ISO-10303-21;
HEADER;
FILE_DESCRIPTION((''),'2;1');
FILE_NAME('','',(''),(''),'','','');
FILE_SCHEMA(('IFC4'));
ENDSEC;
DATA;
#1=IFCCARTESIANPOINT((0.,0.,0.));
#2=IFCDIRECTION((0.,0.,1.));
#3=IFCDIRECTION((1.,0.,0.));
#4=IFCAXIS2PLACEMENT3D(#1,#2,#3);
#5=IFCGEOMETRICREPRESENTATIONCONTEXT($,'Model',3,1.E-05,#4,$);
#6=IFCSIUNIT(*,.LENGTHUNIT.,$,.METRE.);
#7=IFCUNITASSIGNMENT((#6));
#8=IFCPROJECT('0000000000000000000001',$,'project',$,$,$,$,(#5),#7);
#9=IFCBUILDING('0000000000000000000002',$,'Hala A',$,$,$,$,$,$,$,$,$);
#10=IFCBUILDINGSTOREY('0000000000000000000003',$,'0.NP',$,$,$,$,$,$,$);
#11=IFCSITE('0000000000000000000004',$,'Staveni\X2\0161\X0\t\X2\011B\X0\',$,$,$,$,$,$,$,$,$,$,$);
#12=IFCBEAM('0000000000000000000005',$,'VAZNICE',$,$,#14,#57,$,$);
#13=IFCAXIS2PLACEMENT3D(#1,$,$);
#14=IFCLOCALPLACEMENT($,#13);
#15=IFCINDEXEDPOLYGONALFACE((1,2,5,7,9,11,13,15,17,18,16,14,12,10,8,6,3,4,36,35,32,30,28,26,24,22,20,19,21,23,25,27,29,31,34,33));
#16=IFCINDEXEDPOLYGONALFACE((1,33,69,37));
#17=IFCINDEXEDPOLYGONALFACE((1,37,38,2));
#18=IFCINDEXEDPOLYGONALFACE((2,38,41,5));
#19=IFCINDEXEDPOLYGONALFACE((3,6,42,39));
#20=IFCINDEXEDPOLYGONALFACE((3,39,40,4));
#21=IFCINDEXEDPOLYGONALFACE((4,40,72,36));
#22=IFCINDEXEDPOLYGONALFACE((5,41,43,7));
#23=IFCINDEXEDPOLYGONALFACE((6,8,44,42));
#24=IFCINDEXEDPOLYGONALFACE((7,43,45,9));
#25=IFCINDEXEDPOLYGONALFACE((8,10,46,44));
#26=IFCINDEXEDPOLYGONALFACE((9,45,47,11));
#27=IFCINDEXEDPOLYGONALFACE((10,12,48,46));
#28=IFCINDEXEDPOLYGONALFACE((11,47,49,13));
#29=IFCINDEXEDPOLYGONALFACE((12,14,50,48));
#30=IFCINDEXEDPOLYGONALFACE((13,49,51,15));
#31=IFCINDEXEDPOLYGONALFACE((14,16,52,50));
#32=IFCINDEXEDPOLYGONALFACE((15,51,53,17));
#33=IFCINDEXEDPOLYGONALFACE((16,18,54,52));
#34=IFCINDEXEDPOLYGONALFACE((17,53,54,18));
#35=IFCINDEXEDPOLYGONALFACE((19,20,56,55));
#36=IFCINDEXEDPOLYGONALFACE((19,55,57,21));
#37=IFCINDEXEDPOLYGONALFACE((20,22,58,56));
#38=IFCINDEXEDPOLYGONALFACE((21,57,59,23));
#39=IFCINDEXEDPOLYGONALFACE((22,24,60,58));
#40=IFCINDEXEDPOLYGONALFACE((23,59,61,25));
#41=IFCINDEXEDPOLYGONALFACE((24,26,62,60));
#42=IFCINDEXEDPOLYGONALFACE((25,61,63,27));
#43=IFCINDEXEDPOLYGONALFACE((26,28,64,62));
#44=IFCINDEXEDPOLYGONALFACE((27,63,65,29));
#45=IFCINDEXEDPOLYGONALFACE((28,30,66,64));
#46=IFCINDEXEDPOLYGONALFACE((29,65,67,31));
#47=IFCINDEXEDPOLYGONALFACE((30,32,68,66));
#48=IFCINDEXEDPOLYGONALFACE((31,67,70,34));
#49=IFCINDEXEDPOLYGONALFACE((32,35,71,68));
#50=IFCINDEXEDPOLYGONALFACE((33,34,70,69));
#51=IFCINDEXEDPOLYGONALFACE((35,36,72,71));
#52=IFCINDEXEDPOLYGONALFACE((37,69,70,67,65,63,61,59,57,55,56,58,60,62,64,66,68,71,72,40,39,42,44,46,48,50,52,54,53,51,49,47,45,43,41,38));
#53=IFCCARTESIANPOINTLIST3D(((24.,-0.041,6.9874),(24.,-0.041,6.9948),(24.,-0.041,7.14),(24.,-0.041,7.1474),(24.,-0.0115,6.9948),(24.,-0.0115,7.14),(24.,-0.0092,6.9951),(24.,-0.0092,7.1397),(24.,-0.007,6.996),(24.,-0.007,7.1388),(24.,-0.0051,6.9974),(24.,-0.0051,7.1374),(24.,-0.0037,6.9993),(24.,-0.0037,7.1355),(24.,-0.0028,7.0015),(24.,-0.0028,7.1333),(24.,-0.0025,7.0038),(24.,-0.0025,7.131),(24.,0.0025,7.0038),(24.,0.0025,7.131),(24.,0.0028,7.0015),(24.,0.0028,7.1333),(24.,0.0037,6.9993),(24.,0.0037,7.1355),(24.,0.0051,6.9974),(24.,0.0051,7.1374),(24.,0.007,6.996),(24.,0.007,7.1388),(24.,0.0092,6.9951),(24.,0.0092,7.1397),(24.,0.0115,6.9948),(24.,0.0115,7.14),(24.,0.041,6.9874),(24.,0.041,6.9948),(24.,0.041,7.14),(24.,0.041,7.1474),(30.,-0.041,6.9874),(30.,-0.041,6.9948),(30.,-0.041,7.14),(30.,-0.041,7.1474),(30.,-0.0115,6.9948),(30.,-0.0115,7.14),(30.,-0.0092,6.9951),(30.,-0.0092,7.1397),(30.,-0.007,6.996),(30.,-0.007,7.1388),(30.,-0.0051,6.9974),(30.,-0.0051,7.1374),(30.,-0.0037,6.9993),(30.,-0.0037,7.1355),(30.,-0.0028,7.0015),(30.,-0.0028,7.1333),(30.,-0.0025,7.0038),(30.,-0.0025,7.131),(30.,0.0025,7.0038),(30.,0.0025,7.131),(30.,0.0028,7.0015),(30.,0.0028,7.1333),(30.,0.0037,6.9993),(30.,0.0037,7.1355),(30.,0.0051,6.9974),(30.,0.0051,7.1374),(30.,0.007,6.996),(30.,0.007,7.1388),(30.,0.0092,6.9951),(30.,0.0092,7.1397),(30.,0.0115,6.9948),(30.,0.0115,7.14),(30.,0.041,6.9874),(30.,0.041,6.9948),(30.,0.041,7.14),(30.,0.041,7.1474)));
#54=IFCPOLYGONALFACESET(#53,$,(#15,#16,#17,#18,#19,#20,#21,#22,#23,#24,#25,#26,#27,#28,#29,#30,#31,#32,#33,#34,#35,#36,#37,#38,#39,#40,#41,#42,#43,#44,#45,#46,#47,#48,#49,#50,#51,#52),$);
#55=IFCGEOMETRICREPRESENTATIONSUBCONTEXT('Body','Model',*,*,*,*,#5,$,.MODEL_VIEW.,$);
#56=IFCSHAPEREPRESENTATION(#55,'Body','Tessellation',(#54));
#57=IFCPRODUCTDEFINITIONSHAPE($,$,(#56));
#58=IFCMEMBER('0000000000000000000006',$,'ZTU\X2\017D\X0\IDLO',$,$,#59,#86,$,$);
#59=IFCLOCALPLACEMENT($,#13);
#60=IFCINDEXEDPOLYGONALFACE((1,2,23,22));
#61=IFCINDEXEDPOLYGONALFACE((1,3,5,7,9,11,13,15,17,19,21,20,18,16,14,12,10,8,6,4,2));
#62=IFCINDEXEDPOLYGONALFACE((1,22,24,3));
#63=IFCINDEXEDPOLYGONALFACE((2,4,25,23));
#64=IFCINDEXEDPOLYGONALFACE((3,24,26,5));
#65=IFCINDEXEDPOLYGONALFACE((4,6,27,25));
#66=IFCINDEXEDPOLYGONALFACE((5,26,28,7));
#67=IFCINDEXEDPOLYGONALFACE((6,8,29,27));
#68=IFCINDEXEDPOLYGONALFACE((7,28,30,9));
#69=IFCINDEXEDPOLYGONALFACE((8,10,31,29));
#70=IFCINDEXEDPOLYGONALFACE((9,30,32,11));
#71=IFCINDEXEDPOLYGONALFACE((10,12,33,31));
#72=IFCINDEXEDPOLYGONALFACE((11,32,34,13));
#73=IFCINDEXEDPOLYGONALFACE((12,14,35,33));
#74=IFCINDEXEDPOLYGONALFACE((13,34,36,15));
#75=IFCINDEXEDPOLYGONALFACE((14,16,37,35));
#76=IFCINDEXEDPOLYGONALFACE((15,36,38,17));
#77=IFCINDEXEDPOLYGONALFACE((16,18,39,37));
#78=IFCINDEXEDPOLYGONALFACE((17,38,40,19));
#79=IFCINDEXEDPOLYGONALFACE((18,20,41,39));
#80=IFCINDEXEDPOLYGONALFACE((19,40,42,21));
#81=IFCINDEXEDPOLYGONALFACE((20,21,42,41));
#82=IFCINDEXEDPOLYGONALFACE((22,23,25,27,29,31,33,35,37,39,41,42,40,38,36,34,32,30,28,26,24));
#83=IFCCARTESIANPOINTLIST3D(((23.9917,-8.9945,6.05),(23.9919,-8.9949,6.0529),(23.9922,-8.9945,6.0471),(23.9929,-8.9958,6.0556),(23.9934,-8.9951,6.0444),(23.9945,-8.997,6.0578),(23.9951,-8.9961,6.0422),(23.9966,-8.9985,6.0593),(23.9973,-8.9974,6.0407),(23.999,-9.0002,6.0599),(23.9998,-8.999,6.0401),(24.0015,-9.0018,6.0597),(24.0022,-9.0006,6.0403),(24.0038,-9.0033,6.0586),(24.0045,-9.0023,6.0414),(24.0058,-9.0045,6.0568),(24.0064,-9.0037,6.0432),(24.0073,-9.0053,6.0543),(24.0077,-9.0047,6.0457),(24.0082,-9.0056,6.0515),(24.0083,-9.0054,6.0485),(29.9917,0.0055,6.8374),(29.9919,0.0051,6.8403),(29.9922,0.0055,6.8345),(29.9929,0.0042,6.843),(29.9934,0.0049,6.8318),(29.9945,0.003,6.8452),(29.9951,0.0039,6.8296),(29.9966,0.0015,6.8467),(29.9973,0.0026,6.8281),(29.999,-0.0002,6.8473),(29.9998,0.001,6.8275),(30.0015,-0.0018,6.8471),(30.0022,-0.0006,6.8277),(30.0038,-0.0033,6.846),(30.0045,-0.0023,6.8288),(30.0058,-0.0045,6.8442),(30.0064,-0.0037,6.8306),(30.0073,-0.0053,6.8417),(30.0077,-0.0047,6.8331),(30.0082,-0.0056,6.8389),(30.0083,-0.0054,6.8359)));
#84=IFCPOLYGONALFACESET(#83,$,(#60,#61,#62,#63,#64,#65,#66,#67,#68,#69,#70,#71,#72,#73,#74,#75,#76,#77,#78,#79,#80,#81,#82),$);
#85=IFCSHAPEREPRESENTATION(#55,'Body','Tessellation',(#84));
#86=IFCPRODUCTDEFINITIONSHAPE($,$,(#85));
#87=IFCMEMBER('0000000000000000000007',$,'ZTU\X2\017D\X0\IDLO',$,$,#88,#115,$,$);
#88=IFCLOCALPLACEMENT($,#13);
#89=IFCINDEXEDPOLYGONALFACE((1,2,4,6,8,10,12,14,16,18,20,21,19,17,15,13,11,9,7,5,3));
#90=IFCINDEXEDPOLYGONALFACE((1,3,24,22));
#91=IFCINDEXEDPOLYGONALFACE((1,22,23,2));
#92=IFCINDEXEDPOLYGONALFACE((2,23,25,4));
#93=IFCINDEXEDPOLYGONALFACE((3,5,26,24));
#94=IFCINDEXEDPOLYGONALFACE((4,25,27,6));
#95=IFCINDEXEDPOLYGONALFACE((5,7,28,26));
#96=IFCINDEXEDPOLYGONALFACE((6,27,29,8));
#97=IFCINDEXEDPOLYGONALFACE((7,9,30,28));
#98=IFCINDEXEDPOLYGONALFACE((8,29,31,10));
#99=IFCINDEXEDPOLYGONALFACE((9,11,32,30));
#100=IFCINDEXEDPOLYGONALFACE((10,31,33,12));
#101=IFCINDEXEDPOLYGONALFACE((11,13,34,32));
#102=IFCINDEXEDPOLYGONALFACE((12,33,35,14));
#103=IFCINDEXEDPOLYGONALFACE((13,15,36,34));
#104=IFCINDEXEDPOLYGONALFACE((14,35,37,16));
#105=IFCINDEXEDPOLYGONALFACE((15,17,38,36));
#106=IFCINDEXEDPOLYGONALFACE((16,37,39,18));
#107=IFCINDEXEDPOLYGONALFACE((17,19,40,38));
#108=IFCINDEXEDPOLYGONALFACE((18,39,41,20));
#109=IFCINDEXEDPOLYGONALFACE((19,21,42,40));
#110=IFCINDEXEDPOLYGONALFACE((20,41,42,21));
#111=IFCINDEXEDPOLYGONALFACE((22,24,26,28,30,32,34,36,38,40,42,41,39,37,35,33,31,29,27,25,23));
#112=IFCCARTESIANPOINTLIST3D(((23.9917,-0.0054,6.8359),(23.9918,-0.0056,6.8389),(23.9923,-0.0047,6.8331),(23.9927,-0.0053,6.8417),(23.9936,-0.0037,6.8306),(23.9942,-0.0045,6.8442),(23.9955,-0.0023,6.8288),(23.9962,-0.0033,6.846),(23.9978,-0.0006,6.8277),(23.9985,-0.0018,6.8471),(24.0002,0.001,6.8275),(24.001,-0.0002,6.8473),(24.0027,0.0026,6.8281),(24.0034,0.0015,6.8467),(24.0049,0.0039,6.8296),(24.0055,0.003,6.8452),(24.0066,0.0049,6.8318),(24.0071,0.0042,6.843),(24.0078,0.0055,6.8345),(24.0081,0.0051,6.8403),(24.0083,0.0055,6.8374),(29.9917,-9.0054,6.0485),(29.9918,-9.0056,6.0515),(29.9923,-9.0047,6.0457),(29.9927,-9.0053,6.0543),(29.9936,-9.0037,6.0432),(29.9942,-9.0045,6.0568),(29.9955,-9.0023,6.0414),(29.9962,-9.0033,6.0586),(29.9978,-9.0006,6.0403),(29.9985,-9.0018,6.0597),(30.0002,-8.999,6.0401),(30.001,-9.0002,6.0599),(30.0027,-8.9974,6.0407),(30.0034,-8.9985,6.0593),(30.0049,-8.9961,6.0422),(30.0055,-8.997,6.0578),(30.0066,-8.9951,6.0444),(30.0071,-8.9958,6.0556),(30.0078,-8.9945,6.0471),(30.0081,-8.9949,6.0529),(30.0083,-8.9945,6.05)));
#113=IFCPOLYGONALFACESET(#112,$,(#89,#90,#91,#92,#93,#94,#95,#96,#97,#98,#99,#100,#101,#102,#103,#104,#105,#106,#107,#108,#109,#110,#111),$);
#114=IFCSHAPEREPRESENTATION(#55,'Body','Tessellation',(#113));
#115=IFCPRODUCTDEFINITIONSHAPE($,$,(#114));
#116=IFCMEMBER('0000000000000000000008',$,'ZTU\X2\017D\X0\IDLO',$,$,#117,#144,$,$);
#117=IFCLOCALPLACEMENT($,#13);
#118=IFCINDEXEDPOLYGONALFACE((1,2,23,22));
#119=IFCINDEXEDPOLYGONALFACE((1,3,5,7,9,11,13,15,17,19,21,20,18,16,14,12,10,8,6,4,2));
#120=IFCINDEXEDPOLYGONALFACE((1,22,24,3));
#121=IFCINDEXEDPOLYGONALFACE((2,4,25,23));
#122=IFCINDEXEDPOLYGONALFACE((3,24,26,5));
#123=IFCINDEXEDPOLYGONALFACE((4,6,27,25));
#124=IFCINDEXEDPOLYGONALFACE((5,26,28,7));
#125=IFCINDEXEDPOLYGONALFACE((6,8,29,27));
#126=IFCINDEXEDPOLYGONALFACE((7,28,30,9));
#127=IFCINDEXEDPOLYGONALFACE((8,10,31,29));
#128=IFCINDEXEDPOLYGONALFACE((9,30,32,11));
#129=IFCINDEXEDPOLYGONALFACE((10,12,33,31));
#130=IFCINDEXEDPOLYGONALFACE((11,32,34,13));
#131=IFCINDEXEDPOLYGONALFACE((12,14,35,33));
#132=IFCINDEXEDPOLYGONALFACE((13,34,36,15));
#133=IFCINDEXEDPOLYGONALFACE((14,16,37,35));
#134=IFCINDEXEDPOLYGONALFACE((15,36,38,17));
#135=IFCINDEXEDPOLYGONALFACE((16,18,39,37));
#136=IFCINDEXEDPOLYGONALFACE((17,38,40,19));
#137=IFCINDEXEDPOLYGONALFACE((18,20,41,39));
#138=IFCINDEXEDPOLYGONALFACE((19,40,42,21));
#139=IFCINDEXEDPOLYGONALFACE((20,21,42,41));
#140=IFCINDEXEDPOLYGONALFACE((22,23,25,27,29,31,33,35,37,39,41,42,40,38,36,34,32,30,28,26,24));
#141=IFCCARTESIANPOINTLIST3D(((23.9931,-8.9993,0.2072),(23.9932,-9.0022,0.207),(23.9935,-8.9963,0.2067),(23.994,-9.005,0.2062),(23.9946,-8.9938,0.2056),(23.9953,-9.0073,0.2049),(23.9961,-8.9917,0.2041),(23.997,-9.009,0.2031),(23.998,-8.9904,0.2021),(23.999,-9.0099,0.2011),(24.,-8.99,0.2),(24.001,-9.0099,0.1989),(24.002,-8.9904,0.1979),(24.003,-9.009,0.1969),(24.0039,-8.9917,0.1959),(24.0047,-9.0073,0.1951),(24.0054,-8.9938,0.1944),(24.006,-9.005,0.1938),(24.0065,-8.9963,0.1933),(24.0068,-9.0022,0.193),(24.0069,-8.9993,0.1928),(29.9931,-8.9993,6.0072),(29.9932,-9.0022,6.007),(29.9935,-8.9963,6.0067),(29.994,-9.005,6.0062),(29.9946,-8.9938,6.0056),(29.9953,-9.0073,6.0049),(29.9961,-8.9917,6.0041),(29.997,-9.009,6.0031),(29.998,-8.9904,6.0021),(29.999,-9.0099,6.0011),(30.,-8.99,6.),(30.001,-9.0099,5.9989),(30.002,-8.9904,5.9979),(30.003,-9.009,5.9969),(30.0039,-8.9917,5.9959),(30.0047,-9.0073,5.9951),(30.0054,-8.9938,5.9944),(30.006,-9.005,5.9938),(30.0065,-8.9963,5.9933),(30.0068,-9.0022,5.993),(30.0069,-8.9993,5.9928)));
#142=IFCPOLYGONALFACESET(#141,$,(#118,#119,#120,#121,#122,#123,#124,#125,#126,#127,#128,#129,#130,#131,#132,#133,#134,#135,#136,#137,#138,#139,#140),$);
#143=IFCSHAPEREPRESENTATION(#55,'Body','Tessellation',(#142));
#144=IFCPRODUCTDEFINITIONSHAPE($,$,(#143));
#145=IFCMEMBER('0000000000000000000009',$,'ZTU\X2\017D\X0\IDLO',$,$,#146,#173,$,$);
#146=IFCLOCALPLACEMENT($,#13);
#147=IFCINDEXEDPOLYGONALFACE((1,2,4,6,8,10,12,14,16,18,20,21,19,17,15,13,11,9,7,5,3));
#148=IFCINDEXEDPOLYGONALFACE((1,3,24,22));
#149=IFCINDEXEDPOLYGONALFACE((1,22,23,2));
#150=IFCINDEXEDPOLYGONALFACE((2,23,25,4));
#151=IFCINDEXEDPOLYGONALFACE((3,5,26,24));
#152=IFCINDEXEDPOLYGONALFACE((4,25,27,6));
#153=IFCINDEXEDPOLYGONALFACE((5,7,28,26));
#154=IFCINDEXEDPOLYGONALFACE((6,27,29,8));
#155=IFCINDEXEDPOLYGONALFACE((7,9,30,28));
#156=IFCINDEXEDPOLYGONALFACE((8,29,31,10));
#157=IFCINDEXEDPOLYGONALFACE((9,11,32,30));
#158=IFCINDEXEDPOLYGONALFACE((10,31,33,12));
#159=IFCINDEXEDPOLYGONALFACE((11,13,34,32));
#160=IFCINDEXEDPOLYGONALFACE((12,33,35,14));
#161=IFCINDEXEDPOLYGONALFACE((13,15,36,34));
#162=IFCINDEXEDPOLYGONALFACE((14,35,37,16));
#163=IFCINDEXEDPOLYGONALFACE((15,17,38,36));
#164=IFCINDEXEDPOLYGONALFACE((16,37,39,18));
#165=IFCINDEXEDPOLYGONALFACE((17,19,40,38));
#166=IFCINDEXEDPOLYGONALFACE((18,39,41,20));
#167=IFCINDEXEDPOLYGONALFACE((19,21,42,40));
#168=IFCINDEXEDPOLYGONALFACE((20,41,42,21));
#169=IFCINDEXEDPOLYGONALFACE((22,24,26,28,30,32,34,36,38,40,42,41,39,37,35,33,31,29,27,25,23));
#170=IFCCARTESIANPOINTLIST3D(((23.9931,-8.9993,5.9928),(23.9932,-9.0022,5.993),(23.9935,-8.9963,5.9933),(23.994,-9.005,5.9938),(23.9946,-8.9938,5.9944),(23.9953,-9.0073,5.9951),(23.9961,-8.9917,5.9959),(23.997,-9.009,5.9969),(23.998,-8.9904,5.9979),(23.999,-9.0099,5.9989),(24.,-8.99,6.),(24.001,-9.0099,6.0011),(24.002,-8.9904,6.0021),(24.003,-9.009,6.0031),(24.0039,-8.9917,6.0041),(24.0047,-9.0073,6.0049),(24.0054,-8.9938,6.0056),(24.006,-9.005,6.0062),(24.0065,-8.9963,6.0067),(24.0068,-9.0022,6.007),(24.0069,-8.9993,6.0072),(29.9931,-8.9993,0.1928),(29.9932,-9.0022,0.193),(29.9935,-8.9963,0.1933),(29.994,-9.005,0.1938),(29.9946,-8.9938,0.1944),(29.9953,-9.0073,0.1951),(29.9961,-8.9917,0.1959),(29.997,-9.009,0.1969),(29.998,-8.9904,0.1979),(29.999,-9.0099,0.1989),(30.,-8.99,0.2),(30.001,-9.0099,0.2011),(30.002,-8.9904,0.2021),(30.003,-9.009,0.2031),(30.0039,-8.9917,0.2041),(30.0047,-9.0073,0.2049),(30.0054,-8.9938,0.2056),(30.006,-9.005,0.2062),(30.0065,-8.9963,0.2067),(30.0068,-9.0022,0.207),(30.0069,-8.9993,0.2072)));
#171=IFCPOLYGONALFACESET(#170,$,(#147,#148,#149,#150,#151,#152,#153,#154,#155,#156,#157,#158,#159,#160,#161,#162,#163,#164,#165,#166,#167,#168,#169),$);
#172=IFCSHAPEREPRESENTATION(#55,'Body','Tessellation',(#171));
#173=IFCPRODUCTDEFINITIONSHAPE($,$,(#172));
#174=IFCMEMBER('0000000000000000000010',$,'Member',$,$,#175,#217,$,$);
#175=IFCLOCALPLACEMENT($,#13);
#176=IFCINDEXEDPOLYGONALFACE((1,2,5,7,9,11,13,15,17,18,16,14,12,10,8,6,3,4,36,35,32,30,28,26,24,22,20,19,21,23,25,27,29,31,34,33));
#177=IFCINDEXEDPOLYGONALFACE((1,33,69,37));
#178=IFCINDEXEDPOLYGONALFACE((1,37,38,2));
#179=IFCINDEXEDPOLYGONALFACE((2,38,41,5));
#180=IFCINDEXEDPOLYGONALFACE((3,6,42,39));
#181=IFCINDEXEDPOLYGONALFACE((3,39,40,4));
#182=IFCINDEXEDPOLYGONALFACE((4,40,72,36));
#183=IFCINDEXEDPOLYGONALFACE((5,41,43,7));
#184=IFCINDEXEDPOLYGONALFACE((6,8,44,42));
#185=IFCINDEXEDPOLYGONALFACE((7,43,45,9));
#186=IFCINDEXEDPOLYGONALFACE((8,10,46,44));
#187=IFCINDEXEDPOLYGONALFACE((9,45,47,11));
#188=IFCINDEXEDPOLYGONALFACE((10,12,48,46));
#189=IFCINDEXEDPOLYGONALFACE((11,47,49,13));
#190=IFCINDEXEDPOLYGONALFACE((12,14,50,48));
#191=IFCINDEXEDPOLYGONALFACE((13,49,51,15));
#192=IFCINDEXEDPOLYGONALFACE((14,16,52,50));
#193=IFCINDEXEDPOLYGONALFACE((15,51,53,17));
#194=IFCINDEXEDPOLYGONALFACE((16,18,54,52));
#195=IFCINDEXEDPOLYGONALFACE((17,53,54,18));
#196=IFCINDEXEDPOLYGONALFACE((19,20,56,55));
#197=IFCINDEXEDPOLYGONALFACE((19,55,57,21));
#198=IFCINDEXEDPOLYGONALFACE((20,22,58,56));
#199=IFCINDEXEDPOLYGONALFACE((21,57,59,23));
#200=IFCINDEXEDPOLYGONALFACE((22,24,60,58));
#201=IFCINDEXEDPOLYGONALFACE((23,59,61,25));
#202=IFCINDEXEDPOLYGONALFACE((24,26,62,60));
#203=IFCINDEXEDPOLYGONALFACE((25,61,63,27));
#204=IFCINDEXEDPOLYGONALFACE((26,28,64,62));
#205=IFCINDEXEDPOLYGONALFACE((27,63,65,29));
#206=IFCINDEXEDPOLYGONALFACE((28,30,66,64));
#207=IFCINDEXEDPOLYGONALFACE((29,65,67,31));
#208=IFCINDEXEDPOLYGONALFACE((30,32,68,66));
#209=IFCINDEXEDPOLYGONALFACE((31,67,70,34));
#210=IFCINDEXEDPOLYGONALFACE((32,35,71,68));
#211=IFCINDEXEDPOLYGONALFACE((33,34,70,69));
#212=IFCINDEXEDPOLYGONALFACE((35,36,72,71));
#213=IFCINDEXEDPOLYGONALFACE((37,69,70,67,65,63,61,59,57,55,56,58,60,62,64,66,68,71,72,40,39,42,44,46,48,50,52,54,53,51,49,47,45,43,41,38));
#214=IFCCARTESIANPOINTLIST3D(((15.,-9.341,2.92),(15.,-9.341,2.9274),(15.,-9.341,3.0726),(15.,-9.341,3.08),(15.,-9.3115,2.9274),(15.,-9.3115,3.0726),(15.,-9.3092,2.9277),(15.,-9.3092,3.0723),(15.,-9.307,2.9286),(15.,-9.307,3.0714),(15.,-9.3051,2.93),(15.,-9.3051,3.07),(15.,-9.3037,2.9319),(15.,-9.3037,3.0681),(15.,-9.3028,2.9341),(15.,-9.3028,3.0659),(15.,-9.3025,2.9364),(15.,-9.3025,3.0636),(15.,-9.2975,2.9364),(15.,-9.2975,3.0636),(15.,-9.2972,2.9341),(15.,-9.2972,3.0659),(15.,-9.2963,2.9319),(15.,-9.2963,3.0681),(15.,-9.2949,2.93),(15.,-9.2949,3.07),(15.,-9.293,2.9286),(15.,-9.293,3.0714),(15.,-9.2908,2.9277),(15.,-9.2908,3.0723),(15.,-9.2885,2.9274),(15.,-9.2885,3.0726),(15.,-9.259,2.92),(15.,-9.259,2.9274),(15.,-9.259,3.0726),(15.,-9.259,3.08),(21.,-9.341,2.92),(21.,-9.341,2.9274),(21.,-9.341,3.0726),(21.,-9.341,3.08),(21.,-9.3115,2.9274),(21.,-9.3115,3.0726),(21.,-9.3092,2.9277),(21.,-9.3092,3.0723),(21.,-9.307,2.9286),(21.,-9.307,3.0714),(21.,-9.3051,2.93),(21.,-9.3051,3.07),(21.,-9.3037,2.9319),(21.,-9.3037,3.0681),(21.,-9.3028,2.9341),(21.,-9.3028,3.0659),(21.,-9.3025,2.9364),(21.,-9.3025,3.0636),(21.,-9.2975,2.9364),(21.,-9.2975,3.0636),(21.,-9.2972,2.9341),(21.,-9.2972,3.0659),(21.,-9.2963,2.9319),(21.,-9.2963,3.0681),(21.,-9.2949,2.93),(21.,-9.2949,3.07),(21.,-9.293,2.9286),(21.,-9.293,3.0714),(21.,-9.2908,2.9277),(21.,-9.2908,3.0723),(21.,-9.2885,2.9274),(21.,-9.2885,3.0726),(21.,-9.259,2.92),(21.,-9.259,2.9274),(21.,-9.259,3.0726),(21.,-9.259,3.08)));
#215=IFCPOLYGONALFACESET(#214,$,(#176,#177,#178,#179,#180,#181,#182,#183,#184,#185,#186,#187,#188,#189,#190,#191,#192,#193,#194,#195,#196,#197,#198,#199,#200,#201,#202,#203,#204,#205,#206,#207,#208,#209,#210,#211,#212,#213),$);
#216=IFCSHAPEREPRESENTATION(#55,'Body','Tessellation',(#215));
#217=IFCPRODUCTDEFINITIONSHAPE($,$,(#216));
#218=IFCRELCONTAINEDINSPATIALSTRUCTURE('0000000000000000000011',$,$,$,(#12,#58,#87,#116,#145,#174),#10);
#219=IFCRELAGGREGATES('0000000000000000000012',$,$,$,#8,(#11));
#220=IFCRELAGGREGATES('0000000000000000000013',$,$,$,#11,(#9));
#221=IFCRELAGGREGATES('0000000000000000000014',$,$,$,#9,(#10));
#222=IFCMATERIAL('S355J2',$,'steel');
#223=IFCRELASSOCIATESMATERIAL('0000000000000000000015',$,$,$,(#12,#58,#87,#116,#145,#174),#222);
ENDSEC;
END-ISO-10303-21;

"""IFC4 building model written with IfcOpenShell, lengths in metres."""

from ifc_helpers import new_model, si_unit, frame, origin_with_axes, place, context, subcontext, project, spatial, circle, i_section, extrude, material, element, save


model = new_model("IFC4")

# Units and contexts
model_context = context("Model", 3, precision=1e-05, world=origin_with_axes())
body_context = subcontext(model_context, "Body", "Model", "MODEL_VIEW")
ifc_project = project(units=[si_unit("LENGTHUNIT", "METRE")], contexts=[model_context])

# Site, building, storey
site = spatial("IfcSite", under=ifc_project, Name="Staveniště")
building = spatial("IfcBuilding", under=site, Name="Hala A")
storey = spatial("IfcBuildingStorey", under=building, Name="0.NP")

# Shared definitions
ifc_material = material(Name="S355J2", Category="steel")

# Beam
for number, where, z_axis, x_axis, name in (
    (1, (24.0, 0.0, 7.0674), (1.0, 0.0, 0.0), (0.0, 1.0, 0.0), "VAZNICE"),
):
    element("IfcBeam", number, at=place(None, frame(where, z_axis=z_axis, x_axis=x_axis)), inside=storey, material=ifc_material, Name=name, context=body_context, shape_type="SweptSolid", body=[
        extrude(i_section(OverallWidth=0.082, OverallDepth=0.16, WebThickness=0.005, FlangeThickness=0.0074, FilletRadius=0.009), origin_with_axes(), (0.0, 0.0, 1.0), 6.0),
    ])

# Members
for number, where, z_axis, x_axis, name in (
    (2, (24.0, -9.0, 6.05), (0.553236, 0.829854, 0.072603), (-0.83205, 0.5547, 0.0), "ZTUŽIDLO"),
    (3, (24.0, 0.0, 6.8374), (0.553236, -0.829854, -0.072603), (0.83205, 0.5547, 0.0), "ZTUŽIDLO"),
):
    element("IfcMember", number, at=place(None, frame(where, z_axis=z_axis, x_axis=x_axis)), inside=storey, material=ifc_material, Name=name, context=body_context, shape_type="SweptSolid", body=[
        extrude(circle(Radius=0.01), origin_with_axes(), (0.0, 0.0, 1.0), 10.8453),
    ])
for number, where, z_axis, x_axis, name in (
    (4, (24.0, -9.0, 0.2), (0.718988, 0.0, 0.695022), (0.0, 1.0, 0.0), "ZTUŽIDLO"),
    (5, (24.0, -9.0, 6.0), (0.718988, 0.0, -0.695022), (0.0, 1.0, 0.0), "ZTUŽIDLO"),
):
    element("IfcMember", number, at=place(None, frame(where, z_axis=z_axis, x_axis=x_axis)), inside=storey, material=ifc_material, Name=name, context=body_context, shape_type="SweptSolid", body=[
        extrude(circle(Radius=0.01), origin_with_axes(), (0.0, 0.0, 1.0), 8.3451),
    ])
member_placement = place(None, frame((15.0, -9.3, 3.0), z_axis=(1.0, 0.0, 0.0), x_axis=(0.0, 1.0, 0.0)))
element("IfcMember", 6, at=member_placement, inside=storey, material=ifc_material, Name="Member", context=body_context, shape_type="SweptSolid", body=[
    extrude(i_section(OverallWidth=0.082, OverallDepth=0.16, WebThickness=0.005, FlangeThickness=0.0074, FilletRadius=0.009), origin_with_axes(), (0.0, 0.0, 1.0), 6.0),
])

save(model, "model.ifc")
